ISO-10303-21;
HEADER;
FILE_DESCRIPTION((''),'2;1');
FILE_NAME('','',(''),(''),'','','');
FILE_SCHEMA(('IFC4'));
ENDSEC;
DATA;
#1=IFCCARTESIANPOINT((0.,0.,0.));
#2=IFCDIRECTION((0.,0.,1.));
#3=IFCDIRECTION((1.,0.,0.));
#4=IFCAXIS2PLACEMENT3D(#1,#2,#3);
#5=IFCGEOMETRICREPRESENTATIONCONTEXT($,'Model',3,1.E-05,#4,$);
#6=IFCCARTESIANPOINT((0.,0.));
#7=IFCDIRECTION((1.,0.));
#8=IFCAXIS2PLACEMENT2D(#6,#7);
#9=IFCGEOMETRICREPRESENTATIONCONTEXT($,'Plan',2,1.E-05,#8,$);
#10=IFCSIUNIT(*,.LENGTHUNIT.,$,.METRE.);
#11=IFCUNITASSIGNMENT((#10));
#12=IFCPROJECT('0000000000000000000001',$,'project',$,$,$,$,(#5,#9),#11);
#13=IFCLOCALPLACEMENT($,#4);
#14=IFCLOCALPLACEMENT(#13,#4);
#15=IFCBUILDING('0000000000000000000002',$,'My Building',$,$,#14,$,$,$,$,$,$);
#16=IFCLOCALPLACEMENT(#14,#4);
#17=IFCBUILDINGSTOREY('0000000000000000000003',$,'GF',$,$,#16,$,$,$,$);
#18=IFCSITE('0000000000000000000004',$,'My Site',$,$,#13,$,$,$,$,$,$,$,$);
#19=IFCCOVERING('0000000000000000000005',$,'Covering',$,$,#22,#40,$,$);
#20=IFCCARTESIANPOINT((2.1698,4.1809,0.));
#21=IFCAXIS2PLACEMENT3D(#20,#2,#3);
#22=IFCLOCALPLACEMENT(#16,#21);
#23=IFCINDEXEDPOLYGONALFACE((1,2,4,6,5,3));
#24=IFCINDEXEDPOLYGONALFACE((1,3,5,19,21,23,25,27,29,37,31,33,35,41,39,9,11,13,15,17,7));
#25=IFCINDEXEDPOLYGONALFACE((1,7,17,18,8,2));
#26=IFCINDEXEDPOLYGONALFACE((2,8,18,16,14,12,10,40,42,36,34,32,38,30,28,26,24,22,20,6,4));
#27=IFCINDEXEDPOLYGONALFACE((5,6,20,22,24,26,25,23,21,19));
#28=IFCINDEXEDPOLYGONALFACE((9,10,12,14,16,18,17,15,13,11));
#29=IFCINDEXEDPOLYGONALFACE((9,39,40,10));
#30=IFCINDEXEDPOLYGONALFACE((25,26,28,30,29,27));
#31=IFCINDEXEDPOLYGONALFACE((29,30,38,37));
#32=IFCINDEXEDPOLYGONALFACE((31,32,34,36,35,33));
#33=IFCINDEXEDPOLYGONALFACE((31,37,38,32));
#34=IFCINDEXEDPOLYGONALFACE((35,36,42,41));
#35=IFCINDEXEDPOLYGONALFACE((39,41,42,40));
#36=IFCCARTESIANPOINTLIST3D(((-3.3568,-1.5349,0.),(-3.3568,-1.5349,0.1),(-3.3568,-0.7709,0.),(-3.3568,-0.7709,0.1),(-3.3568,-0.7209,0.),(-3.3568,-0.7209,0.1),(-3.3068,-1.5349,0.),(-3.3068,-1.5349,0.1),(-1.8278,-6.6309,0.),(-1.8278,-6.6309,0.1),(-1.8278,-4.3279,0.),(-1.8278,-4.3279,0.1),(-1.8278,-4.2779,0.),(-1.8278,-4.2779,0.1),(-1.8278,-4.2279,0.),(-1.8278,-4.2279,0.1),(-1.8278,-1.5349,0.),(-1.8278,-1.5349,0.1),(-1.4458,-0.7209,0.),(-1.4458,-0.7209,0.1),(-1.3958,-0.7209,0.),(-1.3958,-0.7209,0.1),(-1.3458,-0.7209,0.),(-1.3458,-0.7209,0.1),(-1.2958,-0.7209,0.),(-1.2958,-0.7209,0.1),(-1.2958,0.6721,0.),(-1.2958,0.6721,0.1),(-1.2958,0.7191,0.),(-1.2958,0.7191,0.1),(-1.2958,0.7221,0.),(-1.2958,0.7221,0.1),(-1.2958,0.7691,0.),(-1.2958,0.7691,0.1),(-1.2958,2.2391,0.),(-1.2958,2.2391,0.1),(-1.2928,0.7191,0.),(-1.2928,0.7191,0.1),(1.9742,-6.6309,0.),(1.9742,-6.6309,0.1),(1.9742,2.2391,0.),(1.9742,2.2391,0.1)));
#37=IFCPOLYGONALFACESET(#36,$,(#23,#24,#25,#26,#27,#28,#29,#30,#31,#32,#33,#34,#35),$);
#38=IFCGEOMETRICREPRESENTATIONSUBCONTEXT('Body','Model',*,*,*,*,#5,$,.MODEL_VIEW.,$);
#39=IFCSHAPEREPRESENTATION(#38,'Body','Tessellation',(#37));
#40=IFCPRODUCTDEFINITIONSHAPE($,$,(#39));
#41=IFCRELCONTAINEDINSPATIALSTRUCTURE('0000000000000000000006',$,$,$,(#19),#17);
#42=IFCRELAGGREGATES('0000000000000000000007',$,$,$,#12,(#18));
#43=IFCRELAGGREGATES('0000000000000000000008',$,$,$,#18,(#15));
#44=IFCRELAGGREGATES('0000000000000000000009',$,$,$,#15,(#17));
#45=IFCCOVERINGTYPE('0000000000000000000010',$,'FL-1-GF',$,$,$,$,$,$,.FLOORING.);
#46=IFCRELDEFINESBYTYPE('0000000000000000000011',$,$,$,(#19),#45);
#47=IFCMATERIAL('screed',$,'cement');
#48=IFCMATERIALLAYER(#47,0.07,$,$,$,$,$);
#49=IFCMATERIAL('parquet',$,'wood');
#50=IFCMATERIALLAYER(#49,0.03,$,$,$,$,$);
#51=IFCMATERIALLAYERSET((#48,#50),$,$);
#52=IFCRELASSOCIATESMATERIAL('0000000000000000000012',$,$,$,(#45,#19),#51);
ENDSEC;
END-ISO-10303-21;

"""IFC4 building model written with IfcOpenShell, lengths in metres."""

from ifc_helpers import new_model, si_unit, frame, origin_with_axes, origin_2d_with_axis, place, context, subcontext, project, spatial, line, indexed_curve, outline, extrude, material, layer, layer_set, layer_usage, type_object, element, save


model = new_model("IFC4")

# Units and contexts
model_context = context("Model", 3, precision=1e-05, world=origin_with_axes())
plan_context = context("Plan", 2, precision=1e-05, world=origin_2d_with_axis())
body_context_1 = subcontext(model_context, "Body", "Model", "MODEL_VIEW")
ifc_project = project(units=[si_unit("LENGTHUNIT", "METRE")], contexts=[model_context, plan_context])

# Site, building, storey
site_placement = place(None, origin_with_axes())
site = spatial("IfcSite", under=ifc_project, at=site_placement, Name="My Site")
building_placement = place(site_placement, origin_with_axes())
building = spatial("IfcBuilding", under=site, at=building_placement, Name="My Building")
storey_placement = place(building_placement, origin_with_axes())
storey = spatial("IfcBuildingStorey", under=building, at=storey_placement, Name="GF")

# Covering
ifc_material_1 = material(Name="screed", Category="cement")
ifc_layer_1 = layer(ifc_material_1, 0.07)
ifc_material_2 = material(Name="parquet", Category="wood")
ifc_layer_2 = layer(ifc_material_2, 0.03)
ifc_layer_set_1 = layer_set([ifc_layer_1, ifc_layer_2])
ifc_layer_usage_1 = layer_usage(ifc_layer_set_1, "AXIS3", "POSITIVE", 0.0)
covering_type = type_object("IfcCoveringType", Name="FL-1-GF", PredefinedType="FLOORING", material=ifc_layer_set_1)
covering_placement = place(storey_placement, frame((2.1698, 4.1809, 0.0), z_axis=(0.0, 0.0, 1.0), x_axis=(1.0, 0.0, 0.0)))
element("IfcCovering", 1, at=covering_placement, inside=storey, type_object=covering_type, material=ifc_layer_usage_1, Name="Covering", context=body_context_1, shape_type="SweptSolid", body=[
    extrude(outline(indexed_curve([(-1.4458, -0.7209), (-1.3958, -0.7209), (-1.3458, -0.7209), (-1.2958, -0.7209), (-1.2958, 0.6721), (-1.2958, 0.7191), (-1.2928, 0.7191), (-1.2958, 0.7221), (-1.2958, 0.7221), (-1.2958, 0.7691), (-1.2958, 2.2391), (1.9742, 2.2391), (1.9742, -6.6309), (-1.8278, -6.6309), (-1.8278, -4.3279), (-1.8278, -4.2779), (-1.8278, -4.2779), (-1.8278, -4.2279), (-1.8278, -1.5349), (-3.3068, -1.5349), (-3.3568, -1.5349), (-3.3568, -0.7709), (-3.3568, -0.7209)], segments=[line(1, 2, 3, 4, 5, 6, 7, 8, 9, 10, 11, 12, 13, 14, 15, 16, 17, 18, 19, 20, 21, 22, 23, 1)])), origin_with_axes(), (0.0, 0.0, 1.0), 0.1),
])

save(model, "model.ifc")
